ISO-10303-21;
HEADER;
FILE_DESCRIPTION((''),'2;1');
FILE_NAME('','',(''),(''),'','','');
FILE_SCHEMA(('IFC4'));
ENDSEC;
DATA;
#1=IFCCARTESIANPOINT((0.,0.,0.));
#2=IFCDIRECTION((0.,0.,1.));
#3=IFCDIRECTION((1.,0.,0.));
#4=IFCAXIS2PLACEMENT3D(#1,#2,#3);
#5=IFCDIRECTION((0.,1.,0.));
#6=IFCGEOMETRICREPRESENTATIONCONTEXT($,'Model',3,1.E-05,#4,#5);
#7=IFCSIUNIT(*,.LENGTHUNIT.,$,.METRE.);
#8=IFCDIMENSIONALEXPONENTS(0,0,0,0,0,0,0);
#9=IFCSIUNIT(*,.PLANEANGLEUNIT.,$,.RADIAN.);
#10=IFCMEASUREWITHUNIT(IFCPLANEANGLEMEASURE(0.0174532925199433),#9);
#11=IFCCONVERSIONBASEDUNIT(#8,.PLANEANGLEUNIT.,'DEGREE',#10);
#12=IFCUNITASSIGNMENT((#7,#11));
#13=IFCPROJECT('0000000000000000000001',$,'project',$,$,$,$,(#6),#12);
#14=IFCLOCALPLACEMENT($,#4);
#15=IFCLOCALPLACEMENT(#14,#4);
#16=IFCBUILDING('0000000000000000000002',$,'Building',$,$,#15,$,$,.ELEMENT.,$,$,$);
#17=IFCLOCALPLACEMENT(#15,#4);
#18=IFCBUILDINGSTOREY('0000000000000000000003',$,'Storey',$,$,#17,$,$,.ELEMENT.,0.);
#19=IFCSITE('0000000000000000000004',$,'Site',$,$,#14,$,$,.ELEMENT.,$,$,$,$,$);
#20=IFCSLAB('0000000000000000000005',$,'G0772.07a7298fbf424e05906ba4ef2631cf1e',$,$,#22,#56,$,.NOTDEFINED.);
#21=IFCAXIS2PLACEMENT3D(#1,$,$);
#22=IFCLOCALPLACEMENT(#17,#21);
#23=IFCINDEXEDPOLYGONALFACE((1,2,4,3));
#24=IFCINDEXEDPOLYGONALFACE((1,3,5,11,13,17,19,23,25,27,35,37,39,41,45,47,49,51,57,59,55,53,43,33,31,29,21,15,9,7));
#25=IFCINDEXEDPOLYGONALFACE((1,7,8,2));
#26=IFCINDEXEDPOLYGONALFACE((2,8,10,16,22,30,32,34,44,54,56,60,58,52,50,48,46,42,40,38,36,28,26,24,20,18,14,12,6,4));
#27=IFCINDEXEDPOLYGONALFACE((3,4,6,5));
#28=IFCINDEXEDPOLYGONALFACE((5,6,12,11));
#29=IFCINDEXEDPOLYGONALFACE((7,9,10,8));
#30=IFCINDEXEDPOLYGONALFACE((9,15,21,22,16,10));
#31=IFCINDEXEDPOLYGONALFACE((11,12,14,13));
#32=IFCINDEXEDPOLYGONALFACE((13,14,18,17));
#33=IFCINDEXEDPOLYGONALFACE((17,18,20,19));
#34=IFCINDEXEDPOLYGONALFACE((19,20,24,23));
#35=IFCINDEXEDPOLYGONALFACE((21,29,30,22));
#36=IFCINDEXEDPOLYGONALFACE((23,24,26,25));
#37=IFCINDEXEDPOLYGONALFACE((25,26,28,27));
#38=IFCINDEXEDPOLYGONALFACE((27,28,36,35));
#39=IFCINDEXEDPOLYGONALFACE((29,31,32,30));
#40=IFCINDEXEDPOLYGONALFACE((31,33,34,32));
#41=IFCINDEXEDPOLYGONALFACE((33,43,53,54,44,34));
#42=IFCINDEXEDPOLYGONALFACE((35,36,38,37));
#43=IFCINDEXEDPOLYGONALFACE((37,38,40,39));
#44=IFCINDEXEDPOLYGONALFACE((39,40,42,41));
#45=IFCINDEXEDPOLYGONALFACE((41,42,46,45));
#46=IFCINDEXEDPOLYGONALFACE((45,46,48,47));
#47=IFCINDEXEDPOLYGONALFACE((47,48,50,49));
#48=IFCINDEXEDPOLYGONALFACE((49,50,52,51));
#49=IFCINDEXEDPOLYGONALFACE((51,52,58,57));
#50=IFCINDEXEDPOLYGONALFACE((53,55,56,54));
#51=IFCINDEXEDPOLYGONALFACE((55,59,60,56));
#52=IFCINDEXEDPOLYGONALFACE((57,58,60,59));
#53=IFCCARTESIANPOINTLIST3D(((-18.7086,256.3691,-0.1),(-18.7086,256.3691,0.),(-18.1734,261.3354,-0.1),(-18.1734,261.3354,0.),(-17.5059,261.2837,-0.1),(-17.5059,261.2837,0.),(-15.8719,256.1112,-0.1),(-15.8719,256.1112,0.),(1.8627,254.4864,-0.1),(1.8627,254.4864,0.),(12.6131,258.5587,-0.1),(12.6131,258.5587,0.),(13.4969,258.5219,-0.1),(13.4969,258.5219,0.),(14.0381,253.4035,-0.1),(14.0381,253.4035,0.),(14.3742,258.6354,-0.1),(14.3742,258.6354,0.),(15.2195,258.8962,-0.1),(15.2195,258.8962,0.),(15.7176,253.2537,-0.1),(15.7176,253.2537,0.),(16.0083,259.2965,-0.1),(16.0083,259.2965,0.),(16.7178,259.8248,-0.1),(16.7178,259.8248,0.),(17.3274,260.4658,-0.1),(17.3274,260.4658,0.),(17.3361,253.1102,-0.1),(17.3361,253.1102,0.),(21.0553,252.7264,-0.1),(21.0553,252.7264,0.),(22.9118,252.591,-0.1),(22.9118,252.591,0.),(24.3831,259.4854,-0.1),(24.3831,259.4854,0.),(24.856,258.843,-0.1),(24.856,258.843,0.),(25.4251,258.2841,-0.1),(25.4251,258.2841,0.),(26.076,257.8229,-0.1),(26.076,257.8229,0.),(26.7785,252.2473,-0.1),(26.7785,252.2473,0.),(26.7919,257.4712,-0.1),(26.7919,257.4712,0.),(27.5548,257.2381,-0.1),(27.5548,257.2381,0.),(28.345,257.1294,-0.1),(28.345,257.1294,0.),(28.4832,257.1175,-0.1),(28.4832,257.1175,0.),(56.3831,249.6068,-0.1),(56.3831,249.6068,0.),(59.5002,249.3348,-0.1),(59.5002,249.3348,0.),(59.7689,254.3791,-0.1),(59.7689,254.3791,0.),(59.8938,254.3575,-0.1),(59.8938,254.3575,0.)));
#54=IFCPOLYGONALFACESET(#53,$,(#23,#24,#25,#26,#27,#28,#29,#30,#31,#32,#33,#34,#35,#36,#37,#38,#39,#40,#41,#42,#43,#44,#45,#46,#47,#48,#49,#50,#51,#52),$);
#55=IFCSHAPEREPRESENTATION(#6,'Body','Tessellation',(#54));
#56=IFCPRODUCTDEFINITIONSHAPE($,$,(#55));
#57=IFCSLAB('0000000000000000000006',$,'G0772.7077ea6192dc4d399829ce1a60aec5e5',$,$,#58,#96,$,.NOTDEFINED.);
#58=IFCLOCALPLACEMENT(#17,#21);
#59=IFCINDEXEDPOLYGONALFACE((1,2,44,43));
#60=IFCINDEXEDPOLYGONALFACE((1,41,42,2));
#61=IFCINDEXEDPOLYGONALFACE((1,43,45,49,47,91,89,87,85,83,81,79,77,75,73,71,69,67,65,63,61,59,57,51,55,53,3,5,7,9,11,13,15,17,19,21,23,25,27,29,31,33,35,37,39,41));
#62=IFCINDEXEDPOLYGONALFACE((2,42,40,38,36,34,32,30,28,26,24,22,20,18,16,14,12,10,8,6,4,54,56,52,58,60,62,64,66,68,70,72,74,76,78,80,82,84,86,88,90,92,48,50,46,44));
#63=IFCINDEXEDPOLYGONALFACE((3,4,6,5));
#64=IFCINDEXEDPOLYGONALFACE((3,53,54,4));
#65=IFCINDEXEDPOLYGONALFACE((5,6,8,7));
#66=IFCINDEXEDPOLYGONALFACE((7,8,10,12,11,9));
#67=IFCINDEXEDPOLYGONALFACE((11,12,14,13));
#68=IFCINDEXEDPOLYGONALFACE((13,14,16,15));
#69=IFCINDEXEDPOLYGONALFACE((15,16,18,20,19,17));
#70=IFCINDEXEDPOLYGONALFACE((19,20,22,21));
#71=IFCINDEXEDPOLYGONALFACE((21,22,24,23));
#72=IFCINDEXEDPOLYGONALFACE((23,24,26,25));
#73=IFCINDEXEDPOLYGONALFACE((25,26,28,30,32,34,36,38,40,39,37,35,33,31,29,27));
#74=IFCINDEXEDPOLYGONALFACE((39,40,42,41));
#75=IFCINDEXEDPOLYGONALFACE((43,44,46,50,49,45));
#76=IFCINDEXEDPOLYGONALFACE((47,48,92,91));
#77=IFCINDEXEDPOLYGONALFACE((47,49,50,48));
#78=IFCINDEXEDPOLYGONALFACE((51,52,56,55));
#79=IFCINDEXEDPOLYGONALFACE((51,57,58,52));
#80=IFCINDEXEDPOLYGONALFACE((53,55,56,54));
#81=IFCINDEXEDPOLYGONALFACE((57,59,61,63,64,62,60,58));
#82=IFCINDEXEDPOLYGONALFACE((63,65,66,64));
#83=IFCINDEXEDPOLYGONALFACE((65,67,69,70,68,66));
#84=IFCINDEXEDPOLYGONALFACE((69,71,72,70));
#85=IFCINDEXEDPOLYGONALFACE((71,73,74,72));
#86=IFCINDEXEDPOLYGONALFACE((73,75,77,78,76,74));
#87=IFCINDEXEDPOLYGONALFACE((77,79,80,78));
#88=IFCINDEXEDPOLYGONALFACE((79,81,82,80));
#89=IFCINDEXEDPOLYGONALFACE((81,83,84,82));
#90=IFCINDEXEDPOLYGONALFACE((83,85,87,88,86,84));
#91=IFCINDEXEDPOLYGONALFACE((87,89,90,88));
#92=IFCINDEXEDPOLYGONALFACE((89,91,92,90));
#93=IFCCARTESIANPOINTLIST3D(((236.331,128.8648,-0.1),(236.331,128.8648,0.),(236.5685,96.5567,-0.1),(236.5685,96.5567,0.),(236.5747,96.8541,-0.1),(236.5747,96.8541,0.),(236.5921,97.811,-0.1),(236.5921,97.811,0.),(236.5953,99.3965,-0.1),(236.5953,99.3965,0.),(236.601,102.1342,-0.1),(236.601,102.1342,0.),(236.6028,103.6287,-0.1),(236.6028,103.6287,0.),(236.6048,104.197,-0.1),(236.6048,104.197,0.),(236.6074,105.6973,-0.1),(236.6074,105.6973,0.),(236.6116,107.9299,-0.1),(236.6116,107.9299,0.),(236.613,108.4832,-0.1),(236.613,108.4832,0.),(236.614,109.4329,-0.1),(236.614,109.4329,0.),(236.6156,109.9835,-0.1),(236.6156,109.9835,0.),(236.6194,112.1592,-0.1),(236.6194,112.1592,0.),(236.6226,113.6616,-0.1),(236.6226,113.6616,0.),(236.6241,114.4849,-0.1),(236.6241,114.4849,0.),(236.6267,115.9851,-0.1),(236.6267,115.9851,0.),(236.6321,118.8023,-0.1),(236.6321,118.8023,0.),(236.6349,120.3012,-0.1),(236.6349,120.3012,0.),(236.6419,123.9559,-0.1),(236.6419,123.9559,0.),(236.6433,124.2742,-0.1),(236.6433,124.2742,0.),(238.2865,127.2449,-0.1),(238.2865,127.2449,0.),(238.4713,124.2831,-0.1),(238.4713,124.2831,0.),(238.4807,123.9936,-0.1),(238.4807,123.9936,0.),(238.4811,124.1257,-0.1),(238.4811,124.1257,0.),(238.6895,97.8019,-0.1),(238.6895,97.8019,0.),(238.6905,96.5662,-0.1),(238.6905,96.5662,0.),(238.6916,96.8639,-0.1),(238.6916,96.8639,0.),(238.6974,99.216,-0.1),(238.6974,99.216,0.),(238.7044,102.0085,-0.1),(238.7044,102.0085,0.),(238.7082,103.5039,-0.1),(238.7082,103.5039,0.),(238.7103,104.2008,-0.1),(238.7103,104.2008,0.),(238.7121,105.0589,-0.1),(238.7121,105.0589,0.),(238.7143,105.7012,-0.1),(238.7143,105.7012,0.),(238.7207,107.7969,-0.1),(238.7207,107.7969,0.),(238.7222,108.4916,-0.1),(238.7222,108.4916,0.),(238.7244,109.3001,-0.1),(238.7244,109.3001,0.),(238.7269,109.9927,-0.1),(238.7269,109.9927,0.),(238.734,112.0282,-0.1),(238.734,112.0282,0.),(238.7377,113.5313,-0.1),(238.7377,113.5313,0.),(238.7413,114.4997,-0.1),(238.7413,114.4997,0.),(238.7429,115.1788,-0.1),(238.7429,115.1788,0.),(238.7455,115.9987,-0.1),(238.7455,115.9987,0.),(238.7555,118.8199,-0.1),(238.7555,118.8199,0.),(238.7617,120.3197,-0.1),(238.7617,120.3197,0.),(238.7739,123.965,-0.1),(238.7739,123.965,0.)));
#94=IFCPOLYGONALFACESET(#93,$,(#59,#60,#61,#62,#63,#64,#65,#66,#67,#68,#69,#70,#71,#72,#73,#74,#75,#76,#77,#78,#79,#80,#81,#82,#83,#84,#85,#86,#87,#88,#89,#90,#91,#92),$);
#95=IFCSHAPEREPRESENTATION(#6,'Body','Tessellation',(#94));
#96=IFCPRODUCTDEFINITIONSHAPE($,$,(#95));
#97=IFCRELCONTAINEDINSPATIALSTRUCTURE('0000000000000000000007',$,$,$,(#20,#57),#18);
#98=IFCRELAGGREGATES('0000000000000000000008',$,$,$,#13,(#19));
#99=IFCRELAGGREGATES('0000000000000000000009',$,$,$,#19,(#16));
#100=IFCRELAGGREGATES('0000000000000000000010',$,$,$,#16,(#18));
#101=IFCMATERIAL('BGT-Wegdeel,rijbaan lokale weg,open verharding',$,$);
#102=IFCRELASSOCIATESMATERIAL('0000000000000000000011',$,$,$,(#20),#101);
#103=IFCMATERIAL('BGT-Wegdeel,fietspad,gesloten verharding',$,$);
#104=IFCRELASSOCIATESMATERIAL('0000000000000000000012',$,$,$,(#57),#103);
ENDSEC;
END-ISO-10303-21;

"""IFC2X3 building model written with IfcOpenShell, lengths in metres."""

from ifc_helpers import new_model, entity, si_unit, converted_unit, direction, frame, origin_with_axes, place, context, project, spatial, polyline, outline, extrude, material, element, save


model = new_model("IFC2X3")

# Units and contexts
model_context = context("Model", 3, precision=1e-05, world=origin_with_axes(), true_north=direction((0.0, 1.0, 0.0)))
ifc_project = project(units=[si_unit("LENGTHUNIT", "METRE"), converted_unit("PLANEANGLEUNIT", "DEGREE", entity("IfcPlaneAngleMeasure", 0.0174532925199433), si_unit("PLANEANGLEUNIT", "RADIAN"), dimensions=[0, 0, 0, 0, 0, 0, 0])], contexts=[model_context])

# Site, building, storey
site_placement = place(None, origin_with_axes())
site = spatial("IfcSite", under=ifc_project, at=site_placement, Name="Site", CompositionType="ELEMENT")
building_placement = place(site_placement, origin_with_axes())
building = spatial("IfcBuilding", under=site, at=building_placement, Name="Building", CompositionType="ELEMENT")
storey_placement = place(building_placement, origin_with_axes())
storey = spatial("IfcBuildingStorey", under=building, at=storey_placement, Name="Storey", CompositionType="ELEMENT", Elevation=0.0)

# Slabs
ifc_material_1 = material(Name="BGT-Wegdeel,rijbaan lokale weg,open verharding")
slab_1_placement = place(storey_placement, frame((0.0, 0.0, -0.1), z_axis=(0.0, 0.0, 1.0), x_axis=(1.0, 0.0, 0.0)))
element("IfcSlab", 1, at=slab_1_placement, inside=storey, material=ifc_material_1, Name="G0772.07a7298fbf424e05906ba4ef2631cf1e", PredefinedType="NOTDEFINED", context=model_context, shape_type="SweptSolid", body=[
    extrude(outline(polyline([(24.3831, 259.4854), (24.856, 258.843), (25.4251, 258.2841), (26.076, 257.8229), (26.7919, 257.4712), (27.5548, 257.2381), (28.345, 257.1294), (28.4832, 257.1175), (59.7689, 254.3791), (59.8938, 254.3575), (59.5002, 249.3348), (56.3831, 249.6068), (26.7785, 252.2473), (22.9118, 252.591), (21.0553, 252.7264), (17.3361, 253.1102), (15.7176, 253.2537), (14.0381, 253.4035), (1.8627, 254.4864), (-15.8719, 256.1112), (-18.7086, 256.3691), (-18.1734, 261.3354), (-17.5059, 261.2837), (12.6131, 258.5587), (13.4969, 258.5219), (14.3742, 258.6354), (15.2195, 258.8962), (16.0083, 259.2965), (16.7178, 259.8248), (17.3274, 260.4658), (24.3831, 259.4854)])), origin_with_axes(), (0.0, 0.0, 1.0), 0.1),
])
ifc_material_2 = material(Name="BGT-Wegdeel,fietspad,gesloten verharding")
slab_2_placement = place(storey_placement, frame((0.0, 0.0, -0.1), z_axis=(0.0, 0.0, 1.0), x_axis=(1.0, 0.0, 0.0)))
element("IfcSlab", 2, at=slab_2_placement, inside=storey, material=ifc_material_2, Name="G0772.7077ea6192dc4d399829ce1a60aec5e5", PredefinedType="NOTDEFINED", context=model_context, shape_type="SweptSolid", body=[
    extrude(outline(polyline([(238.4713, 124.2831), (238.4811, 124.1257), (238.4807, 123.9936), (238.7739, 123.965), (238.7617, 120.3197), (238.7555, 118.8199), (238.7455, 115.9987), (238.7429, 115.1788), (238.7413, 114.4997), (238.7377, 113.5313), (238.734, 112.0282), (238.7269, 109.9927), (238.7244, 109.3001), (238.7222, 108.4916), (238.7207, 107.7969), (238.7143, 105.7012), (238.7121, 105.0589), (238.7103, 104.2008), (238.7082, 103.5039), (238.7044, 102.0085), (238.6974, 99.216), (238.6895, 97.8019), (238.6916, 96.8639), (238.6905, 96.5662), (236.5685, 96.5567), (236.5747, 96.8541), (236.5921, 97.811), (236.5953, 99.3965), (236.601, 102.1342), (236.6028, 103.6287), (236.6048, 104.197), (236.6074, 105.6973), (236.6116, 107.9299), (236.613, 108.4832), (236.614, 109.4329), (236.6156, 109.9835), (236.6194, 112.1592), (236.6226, 113.6616), (236.6241, 114.4849), (236.6267, 115.9851), (236.6321, 118.8023), (236.6349, 120.3012), (236.6419, 123.9559), (236.6433, 124.2742), (236.331, 128.8648), (238.2865, 127.2449), (238.4713, 124.2831)])), origin_with_axes(), (0.0, 0.0, 1.0), 0.1),
])

save(model, "model.ifc")
